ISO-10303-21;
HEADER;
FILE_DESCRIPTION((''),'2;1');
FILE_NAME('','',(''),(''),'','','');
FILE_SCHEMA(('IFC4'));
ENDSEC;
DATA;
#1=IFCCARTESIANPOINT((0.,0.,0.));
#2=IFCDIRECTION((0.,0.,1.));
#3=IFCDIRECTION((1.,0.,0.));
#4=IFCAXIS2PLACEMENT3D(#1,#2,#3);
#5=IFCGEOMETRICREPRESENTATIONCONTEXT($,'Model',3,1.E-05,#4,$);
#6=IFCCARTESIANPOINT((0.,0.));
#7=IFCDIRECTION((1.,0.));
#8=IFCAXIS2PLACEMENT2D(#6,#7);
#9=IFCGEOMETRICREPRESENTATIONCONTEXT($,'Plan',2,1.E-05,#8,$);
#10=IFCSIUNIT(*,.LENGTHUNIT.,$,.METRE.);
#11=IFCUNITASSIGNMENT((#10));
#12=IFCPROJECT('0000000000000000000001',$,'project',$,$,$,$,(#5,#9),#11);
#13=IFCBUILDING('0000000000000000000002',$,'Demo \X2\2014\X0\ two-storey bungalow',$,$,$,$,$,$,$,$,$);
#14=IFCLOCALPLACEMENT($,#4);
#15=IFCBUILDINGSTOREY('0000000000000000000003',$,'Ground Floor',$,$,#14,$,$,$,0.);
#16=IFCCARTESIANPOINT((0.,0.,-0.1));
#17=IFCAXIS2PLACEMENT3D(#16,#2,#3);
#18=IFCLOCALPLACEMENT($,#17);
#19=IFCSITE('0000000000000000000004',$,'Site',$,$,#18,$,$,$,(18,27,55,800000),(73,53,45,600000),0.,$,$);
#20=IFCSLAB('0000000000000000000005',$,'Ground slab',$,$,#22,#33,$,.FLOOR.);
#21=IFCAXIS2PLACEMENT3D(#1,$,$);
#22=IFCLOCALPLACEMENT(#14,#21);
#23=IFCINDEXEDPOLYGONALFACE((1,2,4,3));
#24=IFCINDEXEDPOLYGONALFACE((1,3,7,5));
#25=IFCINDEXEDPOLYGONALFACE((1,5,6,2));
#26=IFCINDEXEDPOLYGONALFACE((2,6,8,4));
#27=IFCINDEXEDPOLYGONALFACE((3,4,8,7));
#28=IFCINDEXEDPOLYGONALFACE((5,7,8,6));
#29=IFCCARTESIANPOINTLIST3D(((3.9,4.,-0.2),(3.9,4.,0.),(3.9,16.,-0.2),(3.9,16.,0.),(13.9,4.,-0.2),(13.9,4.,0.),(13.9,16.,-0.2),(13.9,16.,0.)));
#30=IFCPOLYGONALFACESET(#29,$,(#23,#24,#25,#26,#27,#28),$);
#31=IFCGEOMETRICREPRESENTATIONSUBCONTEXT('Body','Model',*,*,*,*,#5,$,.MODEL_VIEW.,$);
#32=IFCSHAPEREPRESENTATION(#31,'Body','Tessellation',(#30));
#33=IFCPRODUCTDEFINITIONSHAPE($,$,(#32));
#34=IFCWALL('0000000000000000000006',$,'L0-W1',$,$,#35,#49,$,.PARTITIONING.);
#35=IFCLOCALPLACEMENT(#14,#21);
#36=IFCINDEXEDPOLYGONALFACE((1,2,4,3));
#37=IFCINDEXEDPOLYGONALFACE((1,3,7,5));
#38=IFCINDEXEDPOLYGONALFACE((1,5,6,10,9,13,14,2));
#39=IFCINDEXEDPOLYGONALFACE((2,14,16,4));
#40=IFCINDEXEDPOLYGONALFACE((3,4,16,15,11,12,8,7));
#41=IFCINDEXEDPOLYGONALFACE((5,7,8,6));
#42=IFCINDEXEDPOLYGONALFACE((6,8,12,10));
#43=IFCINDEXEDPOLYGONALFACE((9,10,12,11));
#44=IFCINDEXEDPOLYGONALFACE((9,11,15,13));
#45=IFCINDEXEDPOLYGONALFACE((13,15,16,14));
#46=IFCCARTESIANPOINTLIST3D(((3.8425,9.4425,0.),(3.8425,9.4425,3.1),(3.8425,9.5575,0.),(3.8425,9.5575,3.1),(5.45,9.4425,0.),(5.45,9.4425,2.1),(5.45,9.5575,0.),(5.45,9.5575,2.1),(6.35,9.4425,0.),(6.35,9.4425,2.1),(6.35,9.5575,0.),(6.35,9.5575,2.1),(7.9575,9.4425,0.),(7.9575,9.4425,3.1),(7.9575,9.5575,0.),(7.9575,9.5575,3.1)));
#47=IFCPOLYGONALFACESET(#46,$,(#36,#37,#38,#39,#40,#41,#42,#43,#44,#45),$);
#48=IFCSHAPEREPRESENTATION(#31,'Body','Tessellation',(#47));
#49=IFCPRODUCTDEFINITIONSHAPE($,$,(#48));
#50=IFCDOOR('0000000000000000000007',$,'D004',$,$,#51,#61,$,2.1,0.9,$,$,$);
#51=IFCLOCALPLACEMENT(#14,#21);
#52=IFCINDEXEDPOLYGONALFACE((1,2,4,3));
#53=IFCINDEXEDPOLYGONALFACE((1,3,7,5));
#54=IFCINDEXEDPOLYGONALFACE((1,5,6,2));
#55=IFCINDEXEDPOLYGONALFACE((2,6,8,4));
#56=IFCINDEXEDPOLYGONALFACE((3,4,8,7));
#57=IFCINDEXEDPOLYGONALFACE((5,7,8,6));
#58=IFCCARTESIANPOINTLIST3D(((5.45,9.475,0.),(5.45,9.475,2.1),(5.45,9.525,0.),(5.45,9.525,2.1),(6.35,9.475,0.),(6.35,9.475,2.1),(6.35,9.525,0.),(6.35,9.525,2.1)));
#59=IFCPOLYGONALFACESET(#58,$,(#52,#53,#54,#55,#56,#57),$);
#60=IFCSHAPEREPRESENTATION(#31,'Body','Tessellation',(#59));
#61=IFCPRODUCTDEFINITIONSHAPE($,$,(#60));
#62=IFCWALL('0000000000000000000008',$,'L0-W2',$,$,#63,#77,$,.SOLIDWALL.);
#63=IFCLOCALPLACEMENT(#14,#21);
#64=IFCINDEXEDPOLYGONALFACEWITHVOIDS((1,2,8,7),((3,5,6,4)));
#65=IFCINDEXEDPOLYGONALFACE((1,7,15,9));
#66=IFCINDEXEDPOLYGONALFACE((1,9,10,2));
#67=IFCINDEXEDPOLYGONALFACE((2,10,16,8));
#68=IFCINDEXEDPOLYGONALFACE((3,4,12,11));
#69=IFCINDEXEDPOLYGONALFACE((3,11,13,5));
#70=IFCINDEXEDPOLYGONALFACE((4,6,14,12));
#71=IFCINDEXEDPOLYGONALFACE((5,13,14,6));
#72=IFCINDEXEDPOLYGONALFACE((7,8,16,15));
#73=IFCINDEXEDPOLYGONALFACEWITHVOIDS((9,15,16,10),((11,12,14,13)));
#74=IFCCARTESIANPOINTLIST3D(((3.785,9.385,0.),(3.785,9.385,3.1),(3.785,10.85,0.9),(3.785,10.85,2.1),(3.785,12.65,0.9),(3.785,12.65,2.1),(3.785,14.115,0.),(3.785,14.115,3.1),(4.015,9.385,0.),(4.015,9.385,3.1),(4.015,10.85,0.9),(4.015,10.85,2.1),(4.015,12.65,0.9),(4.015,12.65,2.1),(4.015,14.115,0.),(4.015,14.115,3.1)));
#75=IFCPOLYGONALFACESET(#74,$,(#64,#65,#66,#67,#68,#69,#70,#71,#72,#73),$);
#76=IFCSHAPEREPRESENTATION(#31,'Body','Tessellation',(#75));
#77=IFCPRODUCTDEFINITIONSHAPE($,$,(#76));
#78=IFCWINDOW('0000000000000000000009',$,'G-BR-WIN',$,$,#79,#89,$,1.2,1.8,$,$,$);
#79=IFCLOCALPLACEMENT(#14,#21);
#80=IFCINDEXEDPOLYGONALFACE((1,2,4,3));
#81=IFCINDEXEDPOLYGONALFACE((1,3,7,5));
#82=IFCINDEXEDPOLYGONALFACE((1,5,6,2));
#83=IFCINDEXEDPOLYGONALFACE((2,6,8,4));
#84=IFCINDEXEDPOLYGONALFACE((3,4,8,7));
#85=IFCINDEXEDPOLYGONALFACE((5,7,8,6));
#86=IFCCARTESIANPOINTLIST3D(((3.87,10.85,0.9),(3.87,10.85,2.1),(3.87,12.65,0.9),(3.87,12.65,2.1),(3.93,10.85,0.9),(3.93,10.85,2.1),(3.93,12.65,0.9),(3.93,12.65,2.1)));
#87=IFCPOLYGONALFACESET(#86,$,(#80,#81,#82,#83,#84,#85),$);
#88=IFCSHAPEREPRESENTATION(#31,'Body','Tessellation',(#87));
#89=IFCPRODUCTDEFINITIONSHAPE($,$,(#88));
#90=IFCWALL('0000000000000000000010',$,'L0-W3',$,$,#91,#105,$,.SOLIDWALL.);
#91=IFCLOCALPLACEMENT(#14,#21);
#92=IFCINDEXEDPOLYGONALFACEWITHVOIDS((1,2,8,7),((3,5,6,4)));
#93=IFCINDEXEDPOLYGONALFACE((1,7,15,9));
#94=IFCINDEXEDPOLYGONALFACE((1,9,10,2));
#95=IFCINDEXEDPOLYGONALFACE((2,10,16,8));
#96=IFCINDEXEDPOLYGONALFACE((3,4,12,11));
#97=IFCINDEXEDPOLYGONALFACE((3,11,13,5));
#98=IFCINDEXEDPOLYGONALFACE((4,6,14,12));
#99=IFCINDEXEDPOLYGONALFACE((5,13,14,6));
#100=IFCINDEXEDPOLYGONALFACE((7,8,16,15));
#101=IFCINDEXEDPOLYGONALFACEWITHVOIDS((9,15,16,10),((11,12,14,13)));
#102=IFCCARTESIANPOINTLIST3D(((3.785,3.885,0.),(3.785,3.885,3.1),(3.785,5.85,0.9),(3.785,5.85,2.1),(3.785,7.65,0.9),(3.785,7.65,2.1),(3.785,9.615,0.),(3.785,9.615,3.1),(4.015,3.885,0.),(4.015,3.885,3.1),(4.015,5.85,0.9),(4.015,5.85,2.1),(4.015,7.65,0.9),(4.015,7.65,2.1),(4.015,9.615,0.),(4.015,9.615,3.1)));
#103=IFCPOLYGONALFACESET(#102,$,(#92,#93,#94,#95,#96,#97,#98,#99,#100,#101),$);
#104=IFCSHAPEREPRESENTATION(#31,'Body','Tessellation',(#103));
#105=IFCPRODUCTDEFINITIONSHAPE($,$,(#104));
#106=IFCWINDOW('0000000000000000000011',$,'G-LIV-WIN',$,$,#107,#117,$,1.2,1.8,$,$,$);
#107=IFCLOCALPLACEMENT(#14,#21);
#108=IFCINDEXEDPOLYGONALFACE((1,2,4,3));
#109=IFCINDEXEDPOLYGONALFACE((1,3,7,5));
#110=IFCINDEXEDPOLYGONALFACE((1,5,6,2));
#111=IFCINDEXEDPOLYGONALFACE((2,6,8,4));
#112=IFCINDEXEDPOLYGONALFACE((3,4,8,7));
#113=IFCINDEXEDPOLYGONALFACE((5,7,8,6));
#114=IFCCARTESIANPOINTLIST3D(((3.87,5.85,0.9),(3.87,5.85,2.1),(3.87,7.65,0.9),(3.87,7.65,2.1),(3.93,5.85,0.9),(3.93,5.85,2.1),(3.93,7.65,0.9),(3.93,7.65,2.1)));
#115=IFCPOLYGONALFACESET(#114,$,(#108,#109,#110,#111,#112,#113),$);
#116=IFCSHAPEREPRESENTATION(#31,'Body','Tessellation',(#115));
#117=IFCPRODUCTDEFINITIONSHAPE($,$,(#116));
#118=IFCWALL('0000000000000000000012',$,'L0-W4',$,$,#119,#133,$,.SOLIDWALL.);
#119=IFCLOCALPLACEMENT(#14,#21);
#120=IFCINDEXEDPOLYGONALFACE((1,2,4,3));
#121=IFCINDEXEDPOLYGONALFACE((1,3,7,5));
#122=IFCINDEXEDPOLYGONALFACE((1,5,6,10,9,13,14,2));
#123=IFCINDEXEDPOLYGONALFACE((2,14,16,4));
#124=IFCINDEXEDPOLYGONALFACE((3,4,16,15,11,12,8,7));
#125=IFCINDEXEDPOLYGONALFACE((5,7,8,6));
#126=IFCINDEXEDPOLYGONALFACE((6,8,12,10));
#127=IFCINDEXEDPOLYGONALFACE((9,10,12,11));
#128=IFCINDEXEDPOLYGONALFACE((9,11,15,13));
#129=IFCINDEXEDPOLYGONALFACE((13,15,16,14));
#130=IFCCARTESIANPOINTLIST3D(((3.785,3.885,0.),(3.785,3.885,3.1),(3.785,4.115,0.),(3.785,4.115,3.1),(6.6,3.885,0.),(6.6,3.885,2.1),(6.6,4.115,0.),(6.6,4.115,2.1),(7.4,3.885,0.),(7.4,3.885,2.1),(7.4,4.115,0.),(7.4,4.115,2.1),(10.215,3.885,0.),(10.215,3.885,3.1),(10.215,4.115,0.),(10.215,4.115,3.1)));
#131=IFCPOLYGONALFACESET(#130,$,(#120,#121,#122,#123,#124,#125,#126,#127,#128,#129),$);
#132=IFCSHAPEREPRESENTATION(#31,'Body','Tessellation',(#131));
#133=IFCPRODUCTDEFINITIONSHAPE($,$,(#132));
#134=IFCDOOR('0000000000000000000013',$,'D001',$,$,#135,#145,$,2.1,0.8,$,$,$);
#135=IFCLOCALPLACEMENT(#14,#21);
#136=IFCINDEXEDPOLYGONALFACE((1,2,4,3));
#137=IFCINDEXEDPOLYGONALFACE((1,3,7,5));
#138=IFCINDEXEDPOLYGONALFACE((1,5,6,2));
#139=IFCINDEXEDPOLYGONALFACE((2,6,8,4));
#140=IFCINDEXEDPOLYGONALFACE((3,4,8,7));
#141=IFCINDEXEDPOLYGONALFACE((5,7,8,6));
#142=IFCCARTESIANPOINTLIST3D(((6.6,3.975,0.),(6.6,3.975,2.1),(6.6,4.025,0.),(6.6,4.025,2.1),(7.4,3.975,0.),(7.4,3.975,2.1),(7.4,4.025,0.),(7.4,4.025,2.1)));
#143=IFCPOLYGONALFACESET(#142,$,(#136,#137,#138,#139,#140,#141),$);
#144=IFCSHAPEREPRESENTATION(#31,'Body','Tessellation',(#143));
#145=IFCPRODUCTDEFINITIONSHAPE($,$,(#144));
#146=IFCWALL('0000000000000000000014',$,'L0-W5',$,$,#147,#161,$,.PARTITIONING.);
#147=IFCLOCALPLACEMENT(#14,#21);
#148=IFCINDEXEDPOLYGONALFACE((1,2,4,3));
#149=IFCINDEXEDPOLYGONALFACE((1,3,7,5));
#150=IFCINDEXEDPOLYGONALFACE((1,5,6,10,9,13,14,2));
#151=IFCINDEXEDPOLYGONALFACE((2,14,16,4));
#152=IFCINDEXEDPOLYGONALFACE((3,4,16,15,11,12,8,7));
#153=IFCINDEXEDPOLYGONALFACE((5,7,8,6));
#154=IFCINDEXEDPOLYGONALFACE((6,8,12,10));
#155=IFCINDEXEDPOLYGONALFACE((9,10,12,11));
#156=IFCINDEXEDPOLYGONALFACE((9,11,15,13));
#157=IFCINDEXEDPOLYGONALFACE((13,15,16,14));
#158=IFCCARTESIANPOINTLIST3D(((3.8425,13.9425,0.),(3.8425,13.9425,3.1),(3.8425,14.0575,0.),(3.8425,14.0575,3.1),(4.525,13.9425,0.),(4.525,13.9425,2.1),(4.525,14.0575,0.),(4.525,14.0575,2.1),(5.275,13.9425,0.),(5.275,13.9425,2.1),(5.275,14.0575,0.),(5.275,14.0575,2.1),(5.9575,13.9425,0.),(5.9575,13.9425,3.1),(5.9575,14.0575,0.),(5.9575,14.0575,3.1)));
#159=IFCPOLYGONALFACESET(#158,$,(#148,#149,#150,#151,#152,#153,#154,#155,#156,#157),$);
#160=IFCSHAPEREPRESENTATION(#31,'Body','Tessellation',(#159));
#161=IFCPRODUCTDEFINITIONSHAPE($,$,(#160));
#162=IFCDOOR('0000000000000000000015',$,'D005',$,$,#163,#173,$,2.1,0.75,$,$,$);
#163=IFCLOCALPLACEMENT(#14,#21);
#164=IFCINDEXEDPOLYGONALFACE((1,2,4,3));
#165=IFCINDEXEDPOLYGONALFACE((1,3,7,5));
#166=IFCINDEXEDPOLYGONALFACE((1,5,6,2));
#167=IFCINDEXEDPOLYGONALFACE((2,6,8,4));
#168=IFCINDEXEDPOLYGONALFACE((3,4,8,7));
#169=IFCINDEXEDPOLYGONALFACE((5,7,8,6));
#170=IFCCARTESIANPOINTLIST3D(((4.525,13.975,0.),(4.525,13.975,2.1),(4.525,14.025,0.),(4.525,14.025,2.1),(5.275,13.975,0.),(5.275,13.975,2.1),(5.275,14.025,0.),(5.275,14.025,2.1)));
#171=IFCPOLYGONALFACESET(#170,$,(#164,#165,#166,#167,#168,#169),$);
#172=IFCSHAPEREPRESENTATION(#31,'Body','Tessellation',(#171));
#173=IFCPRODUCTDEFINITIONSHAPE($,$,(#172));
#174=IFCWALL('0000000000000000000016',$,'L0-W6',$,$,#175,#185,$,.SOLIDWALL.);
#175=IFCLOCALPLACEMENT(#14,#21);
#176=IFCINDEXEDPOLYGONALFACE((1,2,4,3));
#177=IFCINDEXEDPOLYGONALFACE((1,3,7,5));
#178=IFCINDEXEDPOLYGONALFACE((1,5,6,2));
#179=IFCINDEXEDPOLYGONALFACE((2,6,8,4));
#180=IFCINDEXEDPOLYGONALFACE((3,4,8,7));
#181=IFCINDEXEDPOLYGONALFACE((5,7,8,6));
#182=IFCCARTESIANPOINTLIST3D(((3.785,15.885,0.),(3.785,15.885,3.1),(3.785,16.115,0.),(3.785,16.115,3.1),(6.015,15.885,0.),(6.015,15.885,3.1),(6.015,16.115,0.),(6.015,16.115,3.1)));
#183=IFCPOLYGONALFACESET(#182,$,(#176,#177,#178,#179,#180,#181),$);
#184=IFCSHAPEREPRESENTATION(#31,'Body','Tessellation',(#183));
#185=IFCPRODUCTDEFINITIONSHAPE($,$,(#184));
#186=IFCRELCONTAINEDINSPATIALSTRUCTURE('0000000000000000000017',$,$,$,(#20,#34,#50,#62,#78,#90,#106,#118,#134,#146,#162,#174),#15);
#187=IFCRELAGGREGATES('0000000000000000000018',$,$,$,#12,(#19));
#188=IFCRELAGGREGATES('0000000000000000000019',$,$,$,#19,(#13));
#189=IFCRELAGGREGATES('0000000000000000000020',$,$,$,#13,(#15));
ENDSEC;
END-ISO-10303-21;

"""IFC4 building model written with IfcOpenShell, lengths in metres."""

from ifc_helpers import new_model, si_unit, frame, origin_with_axes, origin_2d_with_axis, place, context, subcontext, project, spatial, line, indexed_curve, outline, extrude, element, fill, save


model = new_model("IFC4")

# Units and contexts
model_context = context("Model", 3, precision=1e-05, world=origin_with_axes())
plan_context = context("Plan", 2, precision=1e-05, world=origin_2d_with_axis())
body_context = subcontext(model_context, "Body", "Model", "MODEL_VIEW")
ifc_project = project(units=[si_unit("LENGTHUNIT", "METRE")], contexts=[model_context, plan_context])

# Site, building, storey
site_placement = place(None, frame((0.0, 0.0, -0.1), z_axis=(0.0, 0.0, 1.0), x_axis=(1.0, 0.0, 0.0)))
site = spatial("IfcSite", under=ifc_project, at=site_placement, Name="Site", RefLatitude=(18, 27, 55, 800000), RefLongitude=(73, 53, 45, 600000), RefElevation=0.0)
building = spatial("IfcBuilding", under=site, Name="Demo — two-storey bungalow")
storey_placement = place(None, origin_with_axes())
storey = spatial("IfcBuildingStorey", under=building, at=storey_placement, Name="Ground Floor", Elevation=0.0)

# Slab
slab_placement = place(storey_placement, frame((0.0, 0.0, -0.2), z_axis=(0.0, 0.0, 1.0), x_axis=(1.0, 0.0, 0.0)))
element("IfcSlab", 1, at=slab_placement, inside=storey, Name="Ground slab", PredefinedType="FLOOR", context=body_context, shape_type="SweptSolid", body=[
    extrude(outline(indexed_curve([(3.9, 4.0), (13.9, 4.0), (13.9, 16.0), (3.9, 16.0)], segments=[line(1, 2, 3, 4, 1)])), origin_with_axes(), (0.0, 0.0, 1.0), 0.2),
])

# Wall, opening, door
wall_1_placement = place(storey_placement, origin_with_axes())
wall_1 = element("IfcWall", 2, at=wall_1_placement, inside=storey, Name="L0-W1", PredefinedType="PARTITIONING", context=body_context, shape_type="SweptSolid", body=[
    extrude(outline(indexed_curve([(7.9575, 9.4425), (3.8425, 9.4425), (3.8425, 9.5575), (7.9575, 9.5575)], segments=[line(1, 2, 3, 4, 1)])), origin_with_axes(), (0.0, 0.0, 1.0), 3.1),
])
opening_1_placement = place(wall_1_placement, origin_with_axes())
opening_1 = element("IfcOpeningElement", 3, at=opening_1_placement, cuts=wall_1, context=body_context, shape_type="SweptSolid", body=[
    extrude(outline(indexed_curve([(6.35, 9.3925), (5.45, 9.3925), (5.45, 9.6075), (6.35, 9.6075)], segments=[line(1, 2, 3, 4, 1)])), origin_with_axes(), (0.0, 0.0, 1.0), 2.1),
])
door_1_placement = place(storey_placement, origin_with_axes())
door_1 = element("IfcDoor", 4, at=door_1_placement, inside=storey, Name="D004", OverallHeight=2.1, OverallWidth=0.9, context=body_context, shape_type="SweptSolid", body=[
    extrude(outline(indexed_curve([(6.35, 9.475), (5.45, 9.475), (5.45, 9.525), (6.35, 9.525)], segments=[line(1, 2, 3, 4, 1)])), origin_with_axes(), (0.0, 0.0, 1.0), 2.1),
])
fill(opening_1, door_1)

# Walls, openings, windows
wall_2_placement = place(storey_placement, origin_with_axes())
wall_2 = element("IfcWall", 5, at=wall_2_placement, inside=storey, Name="L0-W2", PredefinedType="SOLIDWALL", context=body_context, shape_type="SweptSolid", body=[
    extrude(outline(indexed_curve([(4.015, 14.115), (4.015, 9.385), (3.785, 9.385), (3.785, 14.115)], segments=[line(1, 2, 3, 4, 1)])), origin_with_axes(), (0.0, 0.0, 1.0), 3.1),
])
opening_2_placement = place(wall_2_placement, origin_with_axes())
opening_2 = element("IfcOpeningElement", 6, at=opening_2_placement, cuts=wall_2, context=body_context, shape_type="SweptSolid", body=[
    extrude(outline(indexed_curve([(4.065, 12.65), (4.065, 10.85), (3.735, 10.85), (3.735, 12.65)], segments=[line(1, 2, 3, 4, 1)])), frame((0.0, 0.0, 0.9), z_axis=(0.0, 0.0, 1.0), x_axis=(1.0, 0.0, 0.0)), (0.0, 0.0, 1.0), 1.2),
])
window_1_placement = place(storey_placement, origin_with_axes())
window_1 = element("IfcWindow", 7, at=window_1_placement, inside=storey, Name="G-BR-WIN", OverallHeight=1.2, OverallWidth=1.8, context=body_context, shape_type="SweptSolid", body=[
    extrude(outline(indexed_curve([(3.93, 12.65), (3.93, 10.85), (3.87, 10.85), (3.87, 12.65)], segments=[line(1, 2, 3, 4, 1)])), frame((0.0, 0.0, 0.9), z_axis=(0.0, 0.0, 1.0), x_axis=(1.0, 0.0, 0.0)), (0.0, 0.0, 1.0), 1.2),
])
fill(opening_2, window_1)
wall_3_placement = place(storey_placement, origin_with_axes())
wall_3 = element("IfcWall", 8, at=wall_3_placement, inside=storey, Name="L0-W3", PredefinedType="SOLIDWALL", context=body_context, shape_type="SweptSolid", body=[
    extrude(outline(indexed_curve([(4.015, 9.615), (4.015, 3.885), (3.785, 3.885), (3.785, 9.615)], segments=[line(1, 2, 3, 4, 1)])), origin_with_axes(), (0.0, 0.0, 1.0), 3.1),
])
opening_3_placement = place(wall_3_placement, origin_with_axes())
opening_3 = element("IfcOpeningElement", 9, at=opening_3_placement, cuts=wall_3, context=body_context, shape_type="SweptSolid", body=[
    extrude(outline(indexed_curve([(4.065, 7.65), (4.065, 5.85), (3.735, 5.85), (3.735, 7.65)], segments=[line(1, 2, 3, 4, 1)])), frame((0.0, 0.0, 0.9), z_axis=(0.0, 0.0, 1.0), x_axis=(1.0, 0.0, 0.0)), (0.0, 0.0, 1.0), 1.2),
])
window_2_placement = place(storey_placement, origin_with_axes())
window_2 = element("IfcWindow", 10, at=window_2_placement, inside=storey, Name="G-LIV-WIN", OverallHeight=1.2, OverallWidth=1.8, context=body_context, shape_type="SweptSolid", body=[
    extrude(outline(indexed_curve([(3.93, 7.65), (3.93, 5.85), (3.87, 5.85), (3.87, 7.65)], segments=[line(1, 2, 3, 4, 1)])), frame((0.0, 0.0, 0.9), z_axis=(0.0, 0.0, 1.0), x_axis=(1.0, 0.0, 0.0)), (0.0, 0.0, 1.0), 1.2),
])
fill(opening_3, window_2)

# Walls, openings, doors
wall_4_placement = place(storey_placement, origin_with_axes())
wall_4 = element("IfcWall", 11, at=wall_4_placement, inside=storey, Name="L0-W4", PredefinedType="SOLIDWALL", context=body_context, shape_type="SweptSolid", body=[
    extrude(outline(indexed_curve([(3.785, 4.115), (10.215, 4.115), (10.215, 3.885), (3.785, 3.885)], segments=[line(1, 2, 3, 4, 1)])), origin_with_axes(), (0.0, 0.0, 1.0), 3.1),
])
opening_4_placement = place(wall_4_placement, origin_with_axes())
opening_4 = element("IfcOpeningElement", 12, at=opening_4_placement, cuts=wall_4, context=body_context, shape_type="SweptSolid", body=[
    extrude(outline(indexed_curve([(6.6, 4.165), (7.4, 4.165), (7.4, 3.835), (6.6, 3.835)], segments=[line(1, 2, 3, 4, 1)])), origin_with_axes(), (0.0, 0.0, 1.0), 2.1),
])
door_2_placement = place(storey_placement, origin_with_axes())
door_2 = element("IfcDoor", 13, at=door_2_placement, inside=storey, Name="D001", OverallHeight=2.1, OverallWidth=0.8, context=body_context, shape_type="SweptSolid", body=[
    extrude(outline(indexed_curve([(6.6, 4.025), (7.4, 4.025), (7.4, 3.975), (6.6, 3.975)], segments=[line(1, 2, 3, 4, 1)])), origin_with_axes(), (0.0, 0.0, 1.0), 2.1),
])
fill(opening_4, door_2)
wall_5_placement = place(storey_placement, origin_with_axes())
wall_5 = element("IfcWall", 14, at=wall_5_placement, inside=storey, Name="L0-W5", PredefinedType="PARTITIONING", context=body_context, shape_type="SweptSolid", body=[
    extrude(outline(indexed_curve([(5.9575, 13.9425), (3.8425, 13.9425), (3.8425, 14.0575), (5.9575, 14.0575)], segments=[line(1, 2, 3, 4, 1)])), origin_with_axes(), (0.0, 0.0, 1.0), 3.1),
])
opening_5_placement = place(wall_5_placement, origin_with_axes())
opening_5 = element("IfcOpeningElement", 15, at=opening_5_placement, cuts=wall_5, context=body_context, shape_type="SweptSolid", body=[
    extrude(outline(indexed_curve([(5.275, 13.8925), (4.525, 13.8925), (4.525, 14.1075), (5.275, 14.1075)], segments=[line(1, 2, 3, 4, 1)])), origin_with_axes(), (0.0, 0.0, 1.0), 2.1),
])
door_3_placement = place(storey_placement, origin_with_axes())
door_3 = element("IfcDoor", 16, at=door_3_placement, inside=storey, Name="D005", OverallHeight=2.1, OverallWidth=0.75, context=body_context, shape_type="SweptSolid", body=[
    extrude(outline(indexed_curve([(5.275, 13.975), (4.525, 13.975), (4.525, 14.025), (5.275, 14.025)], segments=[line(1, 2, 3, 4, 1)])), origin_with_axes(), (0.0, 0.0, 1.0), 2.1),
])
fill(opening_5, door_3)

# Wall
wall_6_placement = place(storey_placement, origin_with_axes())
element("IfcWall", 17, at=wall_6_placement, inside=storey, Name="L0-W6", PredefinedType="SOLIDWALL", context=body_context, shape_type="SweptSolid", body=[
    extrude(outline(indexed_curve([(6.015, 15.885), (3.785, 15.885), (3.785, 16.115), (6.015, 16.115)], segments=[line(1, 2, 3, 4, 1)])), origin_with_axes(), (0.0, 0.0, 1.0), 3.1),
])

save(model, "model.ifc")
